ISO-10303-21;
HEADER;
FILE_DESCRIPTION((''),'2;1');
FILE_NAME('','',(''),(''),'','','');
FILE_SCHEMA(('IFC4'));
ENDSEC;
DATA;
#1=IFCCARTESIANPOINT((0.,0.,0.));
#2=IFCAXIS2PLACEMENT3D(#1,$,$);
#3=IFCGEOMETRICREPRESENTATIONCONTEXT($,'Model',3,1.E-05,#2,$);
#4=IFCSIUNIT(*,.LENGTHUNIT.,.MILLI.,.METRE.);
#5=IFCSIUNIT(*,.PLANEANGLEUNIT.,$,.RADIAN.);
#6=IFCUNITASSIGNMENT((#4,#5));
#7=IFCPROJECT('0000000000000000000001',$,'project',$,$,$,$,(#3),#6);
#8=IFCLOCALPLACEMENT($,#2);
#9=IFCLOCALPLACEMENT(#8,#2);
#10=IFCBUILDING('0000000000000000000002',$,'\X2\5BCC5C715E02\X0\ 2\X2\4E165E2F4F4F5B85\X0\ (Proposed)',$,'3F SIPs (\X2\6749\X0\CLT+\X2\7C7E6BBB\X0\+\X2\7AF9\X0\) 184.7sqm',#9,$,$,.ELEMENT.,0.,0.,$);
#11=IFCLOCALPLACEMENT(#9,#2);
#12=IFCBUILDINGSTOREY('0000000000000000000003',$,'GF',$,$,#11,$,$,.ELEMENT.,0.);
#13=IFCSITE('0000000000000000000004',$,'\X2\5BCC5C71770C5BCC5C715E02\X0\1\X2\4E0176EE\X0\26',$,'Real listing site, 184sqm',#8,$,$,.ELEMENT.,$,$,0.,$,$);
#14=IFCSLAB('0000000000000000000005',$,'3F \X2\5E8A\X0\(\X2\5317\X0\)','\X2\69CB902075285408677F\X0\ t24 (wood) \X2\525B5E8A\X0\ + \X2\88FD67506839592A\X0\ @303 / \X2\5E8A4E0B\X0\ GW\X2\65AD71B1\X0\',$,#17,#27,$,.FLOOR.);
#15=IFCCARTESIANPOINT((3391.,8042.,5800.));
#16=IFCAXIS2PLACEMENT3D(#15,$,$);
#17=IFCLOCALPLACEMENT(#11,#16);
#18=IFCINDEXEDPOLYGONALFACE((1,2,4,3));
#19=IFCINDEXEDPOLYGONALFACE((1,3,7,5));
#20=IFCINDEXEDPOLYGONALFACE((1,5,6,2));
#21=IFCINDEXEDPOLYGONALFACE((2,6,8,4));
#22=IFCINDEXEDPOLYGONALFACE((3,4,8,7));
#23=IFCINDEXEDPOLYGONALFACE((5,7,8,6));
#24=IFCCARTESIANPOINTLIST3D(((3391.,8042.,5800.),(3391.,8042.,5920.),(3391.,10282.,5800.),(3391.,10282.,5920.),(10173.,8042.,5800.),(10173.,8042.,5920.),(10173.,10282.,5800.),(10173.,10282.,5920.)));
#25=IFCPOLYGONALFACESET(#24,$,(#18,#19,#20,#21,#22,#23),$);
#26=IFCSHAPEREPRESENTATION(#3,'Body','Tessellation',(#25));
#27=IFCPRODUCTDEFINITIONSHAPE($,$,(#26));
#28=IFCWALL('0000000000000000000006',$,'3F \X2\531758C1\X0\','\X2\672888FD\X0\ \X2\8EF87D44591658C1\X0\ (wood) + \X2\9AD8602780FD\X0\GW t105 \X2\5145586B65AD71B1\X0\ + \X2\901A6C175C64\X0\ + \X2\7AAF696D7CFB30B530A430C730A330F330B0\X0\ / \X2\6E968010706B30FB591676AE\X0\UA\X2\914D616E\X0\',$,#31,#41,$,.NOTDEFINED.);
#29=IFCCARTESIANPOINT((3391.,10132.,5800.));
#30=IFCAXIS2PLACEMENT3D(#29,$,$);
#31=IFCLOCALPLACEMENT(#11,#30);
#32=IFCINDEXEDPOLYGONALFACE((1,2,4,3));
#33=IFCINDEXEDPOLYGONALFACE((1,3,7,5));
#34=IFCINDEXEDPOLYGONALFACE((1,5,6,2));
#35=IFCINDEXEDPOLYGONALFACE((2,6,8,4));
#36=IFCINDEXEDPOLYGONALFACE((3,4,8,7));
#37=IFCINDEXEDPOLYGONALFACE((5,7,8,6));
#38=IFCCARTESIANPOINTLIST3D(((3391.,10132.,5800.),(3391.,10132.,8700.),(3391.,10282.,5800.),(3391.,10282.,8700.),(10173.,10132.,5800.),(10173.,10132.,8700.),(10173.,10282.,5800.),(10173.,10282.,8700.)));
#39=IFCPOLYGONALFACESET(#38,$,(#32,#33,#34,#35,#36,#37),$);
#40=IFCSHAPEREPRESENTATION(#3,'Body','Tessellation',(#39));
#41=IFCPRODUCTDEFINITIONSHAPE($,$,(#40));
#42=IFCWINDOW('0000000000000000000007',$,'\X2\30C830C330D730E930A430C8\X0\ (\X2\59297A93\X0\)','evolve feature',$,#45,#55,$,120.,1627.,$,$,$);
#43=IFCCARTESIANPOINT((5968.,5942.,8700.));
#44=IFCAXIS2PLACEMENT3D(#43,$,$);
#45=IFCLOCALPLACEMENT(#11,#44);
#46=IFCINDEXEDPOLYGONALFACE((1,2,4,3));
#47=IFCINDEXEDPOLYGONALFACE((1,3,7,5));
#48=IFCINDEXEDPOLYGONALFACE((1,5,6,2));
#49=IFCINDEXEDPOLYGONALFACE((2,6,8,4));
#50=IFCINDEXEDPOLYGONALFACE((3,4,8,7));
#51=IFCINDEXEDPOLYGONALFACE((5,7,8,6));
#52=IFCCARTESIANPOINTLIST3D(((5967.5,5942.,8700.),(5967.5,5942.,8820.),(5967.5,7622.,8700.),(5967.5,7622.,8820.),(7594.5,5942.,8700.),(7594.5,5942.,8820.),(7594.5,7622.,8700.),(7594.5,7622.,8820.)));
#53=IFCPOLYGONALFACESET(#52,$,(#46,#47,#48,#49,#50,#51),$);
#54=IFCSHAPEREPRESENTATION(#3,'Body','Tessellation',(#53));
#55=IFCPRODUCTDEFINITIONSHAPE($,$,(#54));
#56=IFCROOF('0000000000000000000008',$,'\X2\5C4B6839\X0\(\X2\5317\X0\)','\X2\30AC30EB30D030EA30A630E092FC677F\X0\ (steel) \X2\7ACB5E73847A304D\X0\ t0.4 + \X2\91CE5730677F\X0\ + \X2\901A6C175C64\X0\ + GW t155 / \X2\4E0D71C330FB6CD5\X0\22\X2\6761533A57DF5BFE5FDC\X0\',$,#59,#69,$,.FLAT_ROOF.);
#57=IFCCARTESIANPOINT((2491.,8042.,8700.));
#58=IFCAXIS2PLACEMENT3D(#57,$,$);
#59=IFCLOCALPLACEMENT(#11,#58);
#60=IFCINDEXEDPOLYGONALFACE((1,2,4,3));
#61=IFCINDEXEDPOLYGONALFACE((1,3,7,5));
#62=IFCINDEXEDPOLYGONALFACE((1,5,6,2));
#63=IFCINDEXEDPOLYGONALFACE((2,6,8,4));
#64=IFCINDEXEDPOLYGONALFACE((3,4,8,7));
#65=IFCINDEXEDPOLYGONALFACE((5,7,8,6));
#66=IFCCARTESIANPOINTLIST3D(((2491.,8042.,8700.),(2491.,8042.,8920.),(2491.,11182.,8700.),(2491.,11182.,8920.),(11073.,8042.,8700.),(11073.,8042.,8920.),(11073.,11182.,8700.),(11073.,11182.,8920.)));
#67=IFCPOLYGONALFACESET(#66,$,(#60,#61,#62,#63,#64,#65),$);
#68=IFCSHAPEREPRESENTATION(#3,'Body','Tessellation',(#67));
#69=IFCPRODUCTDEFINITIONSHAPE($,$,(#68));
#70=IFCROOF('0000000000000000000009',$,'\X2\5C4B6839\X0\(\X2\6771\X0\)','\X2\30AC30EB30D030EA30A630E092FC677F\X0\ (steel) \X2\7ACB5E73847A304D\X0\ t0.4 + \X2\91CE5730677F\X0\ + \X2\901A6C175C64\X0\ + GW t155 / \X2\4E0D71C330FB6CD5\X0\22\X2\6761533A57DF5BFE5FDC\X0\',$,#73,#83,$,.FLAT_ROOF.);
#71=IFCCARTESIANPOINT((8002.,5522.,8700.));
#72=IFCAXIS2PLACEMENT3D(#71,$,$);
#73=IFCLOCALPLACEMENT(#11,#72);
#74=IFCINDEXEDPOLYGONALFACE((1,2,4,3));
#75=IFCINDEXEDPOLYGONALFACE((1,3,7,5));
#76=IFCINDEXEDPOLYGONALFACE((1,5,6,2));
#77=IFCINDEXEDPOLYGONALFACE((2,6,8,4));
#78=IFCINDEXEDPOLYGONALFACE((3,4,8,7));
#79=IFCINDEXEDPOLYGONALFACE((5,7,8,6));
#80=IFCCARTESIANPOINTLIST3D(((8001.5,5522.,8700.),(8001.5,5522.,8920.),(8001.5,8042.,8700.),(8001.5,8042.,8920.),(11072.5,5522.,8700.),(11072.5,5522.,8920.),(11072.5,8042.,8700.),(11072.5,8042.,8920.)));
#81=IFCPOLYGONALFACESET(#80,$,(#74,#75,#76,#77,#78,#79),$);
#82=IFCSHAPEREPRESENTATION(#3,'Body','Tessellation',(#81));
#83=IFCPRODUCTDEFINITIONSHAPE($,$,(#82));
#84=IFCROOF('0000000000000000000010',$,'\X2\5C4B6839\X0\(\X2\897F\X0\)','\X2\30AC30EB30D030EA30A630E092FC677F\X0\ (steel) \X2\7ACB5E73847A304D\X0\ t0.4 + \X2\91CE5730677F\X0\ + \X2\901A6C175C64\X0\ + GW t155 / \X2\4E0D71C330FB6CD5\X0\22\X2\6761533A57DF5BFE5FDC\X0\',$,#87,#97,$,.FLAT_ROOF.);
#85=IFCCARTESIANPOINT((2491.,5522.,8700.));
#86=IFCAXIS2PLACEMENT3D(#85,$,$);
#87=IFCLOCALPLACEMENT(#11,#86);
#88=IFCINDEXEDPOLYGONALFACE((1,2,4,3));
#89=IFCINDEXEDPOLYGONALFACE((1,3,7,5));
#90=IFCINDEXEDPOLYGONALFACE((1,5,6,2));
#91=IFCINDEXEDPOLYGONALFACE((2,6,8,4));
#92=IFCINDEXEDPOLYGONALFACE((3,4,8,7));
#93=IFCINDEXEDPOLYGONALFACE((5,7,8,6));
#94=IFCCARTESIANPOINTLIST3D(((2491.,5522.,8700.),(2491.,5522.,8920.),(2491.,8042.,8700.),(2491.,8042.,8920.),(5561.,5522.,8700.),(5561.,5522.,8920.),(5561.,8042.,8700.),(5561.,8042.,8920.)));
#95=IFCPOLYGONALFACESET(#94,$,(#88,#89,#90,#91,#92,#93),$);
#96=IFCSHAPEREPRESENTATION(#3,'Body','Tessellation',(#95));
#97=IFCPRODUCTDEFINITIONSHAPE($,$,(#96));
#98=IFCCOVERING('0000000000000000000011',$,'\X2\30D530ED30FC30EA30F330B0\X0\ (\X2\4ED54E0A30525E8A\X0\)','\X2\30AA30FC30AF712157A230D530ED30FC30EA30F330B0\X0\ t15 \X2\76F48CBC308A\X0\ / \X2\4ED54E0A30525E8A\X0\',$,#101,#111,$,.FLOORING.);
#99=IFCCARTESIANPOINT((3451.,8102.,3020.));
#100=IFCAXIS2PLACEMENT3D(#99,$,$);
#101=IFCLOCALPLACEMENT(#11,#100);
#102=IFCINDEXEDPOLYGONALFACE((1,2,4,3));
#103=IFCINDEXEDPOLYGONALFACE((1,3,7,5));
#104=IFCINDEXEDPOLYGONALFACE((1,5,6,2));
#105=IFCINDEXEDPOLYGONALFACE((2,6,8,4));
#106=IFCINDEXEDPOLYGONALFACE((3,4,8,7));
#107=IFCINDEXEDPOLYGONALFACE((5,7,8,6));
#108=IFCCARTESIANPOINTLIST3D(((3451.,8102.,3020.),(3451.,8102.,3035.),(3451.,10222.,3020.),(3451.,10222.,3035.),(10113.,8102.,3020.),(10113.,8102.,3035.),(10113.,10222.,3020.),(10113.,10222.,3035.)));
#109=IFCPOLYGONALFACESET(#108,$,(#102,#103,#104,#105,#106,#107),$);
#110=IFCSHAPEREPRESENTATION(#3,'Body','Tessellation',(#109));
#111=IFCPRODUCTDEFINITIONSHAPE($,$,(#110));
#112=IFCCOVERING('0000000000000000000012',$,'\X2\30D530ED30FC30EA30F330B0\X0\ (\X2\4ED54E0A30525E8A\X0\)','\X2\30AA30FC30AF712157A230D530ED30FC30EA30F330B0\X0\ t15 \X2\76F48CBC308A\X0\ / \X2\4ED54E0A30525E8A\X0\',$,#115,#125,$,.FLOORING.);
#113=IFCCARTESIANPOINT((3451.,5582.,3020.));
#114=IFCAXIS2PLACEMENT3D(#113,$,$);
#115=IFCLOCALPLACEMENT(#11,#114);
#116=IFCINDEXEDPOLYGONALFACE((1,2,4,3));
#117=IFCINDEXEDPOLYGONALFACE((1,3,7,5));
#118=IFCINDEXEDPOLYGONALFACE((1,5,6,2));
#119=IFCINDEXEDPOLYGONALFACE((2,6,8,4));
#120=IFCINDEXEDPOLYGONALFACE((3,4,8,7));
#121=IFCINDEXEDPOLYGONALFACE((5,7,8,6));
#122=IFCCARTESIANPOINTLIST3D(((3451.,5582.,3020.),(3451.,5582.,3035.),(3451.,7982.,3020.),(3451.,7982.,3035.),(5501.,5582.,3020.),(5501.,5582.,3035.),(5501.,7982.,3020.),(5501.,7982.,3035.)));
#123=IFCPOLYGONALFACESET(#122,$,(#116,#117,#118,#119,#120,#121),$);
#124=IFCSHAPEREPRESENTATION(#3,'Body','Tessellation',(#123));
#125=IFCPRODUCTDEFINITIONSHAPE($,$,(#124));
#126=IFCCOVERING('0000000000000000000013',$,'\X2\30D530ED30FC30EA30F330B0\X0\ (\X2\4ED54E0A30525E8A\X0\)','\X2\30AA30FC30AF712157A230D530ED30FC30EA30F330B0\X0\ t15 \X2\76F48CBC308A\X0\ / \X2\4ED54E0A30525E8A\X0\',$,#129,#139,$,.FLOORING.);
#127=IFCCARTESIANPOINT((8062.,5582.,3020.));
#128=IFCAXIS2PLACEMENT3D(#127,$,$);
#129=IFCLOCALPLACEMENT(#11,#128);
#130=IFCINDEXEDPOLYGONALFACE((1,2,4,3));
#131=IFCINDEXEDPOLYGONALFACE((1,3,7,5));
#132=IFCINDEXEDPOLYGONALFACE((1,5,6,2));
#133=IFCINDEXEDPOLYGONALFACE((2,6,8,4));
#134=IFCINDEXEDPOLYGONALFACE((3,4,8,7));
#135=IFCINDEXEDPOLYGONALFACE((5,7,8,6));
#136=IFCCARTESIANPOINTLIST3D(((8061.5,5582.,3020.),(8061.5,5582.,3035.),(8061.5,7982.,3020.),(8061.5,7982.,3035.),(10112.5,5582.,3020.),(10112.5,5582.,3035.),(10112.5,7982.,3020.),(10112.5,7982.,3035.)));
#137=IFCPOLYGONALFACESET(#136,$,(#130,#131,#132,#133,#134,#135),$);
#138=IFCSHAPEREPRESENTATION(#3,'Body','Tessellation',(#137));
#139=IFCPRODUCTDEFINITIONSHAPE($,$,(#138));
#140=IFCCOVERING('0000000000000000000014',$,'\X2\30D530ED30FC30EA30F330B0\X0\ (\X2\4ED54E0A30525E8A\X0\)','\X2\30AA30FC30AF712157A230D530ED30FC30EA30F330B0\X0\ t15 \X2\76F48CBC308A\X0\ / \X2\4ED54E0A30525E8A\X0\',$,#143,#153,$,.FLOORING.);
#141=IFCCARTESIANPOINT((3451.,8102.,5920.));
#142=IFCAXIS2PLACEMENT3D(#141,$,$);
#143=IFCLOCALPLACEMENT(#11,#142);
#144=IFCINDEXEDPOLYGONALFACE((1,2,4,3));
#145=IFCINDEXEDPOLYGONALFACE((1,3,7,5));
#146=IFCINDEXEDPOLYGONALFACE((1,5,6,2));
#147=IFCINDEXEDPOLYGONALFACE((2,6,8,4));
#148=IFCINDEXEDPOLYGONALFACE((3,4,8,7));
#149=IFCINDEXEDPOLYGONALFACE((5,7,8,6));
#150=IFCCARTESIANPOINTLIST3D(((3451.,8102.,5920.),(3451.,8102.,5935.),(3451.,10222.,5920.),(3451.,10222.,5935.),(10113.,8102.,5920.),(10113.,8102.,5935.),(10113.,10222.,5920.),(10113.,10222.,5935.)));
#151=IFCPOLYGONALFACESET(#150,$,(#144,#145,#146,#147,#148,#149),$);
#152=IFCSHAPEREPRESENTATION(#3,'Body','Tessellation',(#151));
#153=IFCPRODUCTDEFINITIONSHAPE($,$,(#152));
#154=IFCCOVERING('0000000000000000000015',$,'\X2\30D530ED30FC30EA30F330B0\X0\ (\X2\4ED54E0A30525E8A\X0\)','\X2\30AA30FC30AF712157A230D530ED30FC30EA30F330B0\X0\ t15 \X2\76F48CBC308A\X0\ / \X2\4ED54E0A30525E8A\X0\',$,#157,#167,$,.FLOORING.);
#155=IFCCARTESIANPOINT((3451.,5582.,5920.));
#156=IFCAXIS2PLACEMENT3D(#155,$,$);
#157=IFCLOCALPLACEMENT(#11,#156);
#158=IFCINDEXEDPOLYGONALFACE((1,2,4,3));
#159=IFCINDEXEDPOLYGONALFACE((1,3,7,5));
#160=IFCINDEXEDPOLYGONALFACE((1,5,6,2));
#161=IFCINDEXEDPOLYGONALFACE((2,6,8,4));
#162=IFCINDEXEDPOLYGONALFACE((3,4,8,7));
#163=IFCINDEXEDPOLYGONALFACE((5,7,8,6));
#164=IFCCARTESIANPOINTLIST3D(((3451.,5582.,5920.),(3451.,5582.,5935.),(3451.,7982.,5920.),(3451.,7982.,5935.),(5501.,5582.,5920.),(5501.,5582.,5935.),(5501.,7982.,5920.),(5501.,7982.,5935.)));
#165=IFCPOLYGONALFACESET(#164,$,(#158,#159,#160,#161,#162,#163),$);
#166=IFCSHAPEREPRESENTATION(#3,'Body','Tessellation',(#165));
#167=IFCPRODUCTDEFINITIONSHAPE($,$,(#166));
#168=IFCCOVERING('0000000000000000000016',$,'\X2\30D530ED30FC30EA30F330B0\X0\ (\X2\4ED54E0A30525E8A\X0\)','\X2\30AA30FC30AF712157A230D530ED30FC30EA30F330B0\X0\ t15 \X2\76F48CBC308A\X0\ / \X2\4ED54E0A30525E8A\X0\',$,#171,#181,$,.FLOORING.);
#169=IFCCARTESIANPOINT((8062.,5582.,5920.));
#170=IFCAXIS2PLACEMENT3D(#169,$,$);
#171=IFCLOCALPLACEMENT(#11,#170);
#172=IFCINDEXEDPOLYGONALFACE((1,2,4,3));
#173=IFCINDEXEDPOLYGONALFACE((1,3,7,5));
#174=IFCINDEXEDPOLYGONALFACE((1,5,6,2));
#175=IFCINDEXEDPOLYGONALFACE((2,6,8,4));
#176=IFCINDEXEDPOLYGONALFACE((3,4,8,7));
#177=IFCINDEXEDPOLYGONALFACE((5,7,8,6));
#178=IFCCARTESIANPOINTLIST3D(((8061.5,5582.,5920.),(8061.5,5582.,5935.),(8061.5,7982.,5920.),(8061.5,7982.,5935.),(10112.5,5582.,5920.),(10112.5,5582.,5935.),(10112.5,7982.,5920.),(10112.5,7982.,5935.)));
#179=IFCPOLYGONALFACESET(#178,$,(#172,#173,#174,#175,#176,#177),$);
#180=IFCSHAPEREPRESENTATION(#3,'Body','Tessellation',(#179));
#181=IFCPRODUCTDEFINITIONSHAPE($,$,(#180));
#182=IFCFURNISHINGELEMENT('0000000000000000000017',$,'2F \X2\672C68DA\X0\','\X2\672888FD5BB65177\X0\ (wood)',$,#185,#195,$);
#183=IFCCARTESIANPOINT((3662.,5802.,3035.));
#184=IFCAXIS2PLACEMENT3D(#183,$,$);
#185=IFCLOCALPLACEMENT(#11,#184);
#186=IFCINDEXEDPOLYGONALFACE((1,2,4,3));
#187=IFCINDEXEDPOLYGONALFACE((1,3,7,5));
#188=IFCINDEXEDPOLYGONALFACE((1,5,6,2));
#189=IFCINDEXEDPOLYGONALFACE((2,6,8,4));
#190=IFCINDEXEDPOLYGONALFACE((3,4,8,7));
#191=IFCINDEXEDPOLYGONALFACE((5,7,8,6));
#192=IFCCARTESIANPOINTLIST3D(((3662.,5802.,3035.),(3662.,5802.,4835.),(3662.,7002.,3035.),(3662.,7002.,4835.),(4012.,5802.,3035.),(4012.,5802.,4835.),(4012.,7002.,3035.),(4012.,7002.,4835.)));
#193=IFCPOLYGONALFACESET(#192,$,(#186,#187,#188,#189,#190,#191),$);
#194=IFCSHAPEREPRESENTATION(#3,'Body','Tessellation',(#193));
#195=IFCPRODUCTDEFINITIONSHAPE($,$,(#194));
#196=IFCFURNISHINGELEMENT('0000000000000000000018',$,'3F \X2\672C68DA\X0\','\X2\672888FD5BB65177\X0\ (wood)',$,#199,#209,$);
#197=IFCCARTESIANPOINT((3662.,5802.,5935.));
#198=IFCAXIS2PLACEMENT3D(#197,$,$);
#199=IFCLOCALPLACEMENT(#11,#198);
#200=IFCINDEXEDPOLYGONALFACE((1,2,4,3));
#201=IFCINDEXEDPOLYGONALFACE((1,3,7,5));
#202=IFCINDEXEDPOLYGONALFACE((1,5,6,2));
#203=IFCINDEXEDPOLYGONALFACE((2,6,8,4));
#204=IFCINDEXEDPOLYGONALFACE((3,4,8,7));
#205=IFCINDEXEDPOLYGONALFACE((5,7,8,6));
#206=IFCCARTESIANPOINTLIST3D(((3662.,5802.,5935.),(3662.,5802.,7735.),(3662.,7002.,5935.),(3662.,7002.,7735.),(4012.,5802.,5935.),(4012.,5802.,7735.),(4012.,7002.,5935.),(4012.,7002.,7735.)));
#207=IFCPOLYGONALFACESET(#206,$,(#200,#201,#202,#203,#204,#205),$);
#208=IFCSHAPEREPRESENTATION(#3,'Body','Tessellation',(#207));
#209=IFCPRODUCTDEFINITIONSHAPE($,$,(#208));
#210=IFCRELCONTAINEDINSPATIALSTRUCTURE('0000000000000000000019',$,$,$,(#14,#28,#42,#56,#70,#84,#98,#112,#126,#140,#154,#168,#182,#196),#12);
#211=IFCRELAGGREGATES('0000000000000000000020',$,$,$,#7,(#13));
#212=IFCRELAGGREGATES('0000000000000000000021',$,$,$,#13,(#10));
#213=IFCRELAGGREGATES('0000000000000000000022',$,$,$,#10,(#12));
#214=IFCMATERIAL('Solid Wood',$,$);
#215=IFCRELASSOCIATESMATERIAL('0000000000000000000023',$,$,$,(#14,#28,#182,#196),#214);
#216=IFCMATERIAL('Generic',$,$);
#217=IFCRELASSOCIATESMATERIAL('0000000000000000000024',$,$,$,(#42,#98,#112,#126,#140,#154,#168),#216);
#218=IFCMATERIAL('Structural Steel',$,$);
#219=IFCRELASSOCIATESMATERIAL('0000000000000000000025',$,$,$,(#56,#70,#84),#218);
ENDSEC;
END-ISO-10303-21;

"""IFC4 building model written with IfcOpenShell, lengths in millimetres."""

from ifc_helpers import new_model, si_unit, frame, frame_2d, origin, place, context, project, spatial, rectangle, extrude, material, element, save


model = new_model("IFC4")

# Units and contexts
model_context = context("Model", 3, precision=1e-05, world=origin())
ifc_project = project(units=[si_unit("LENGTHUNIT", "METRE", prefix="MILLI"), si_unit("PLANEANGLEUNIT", "RADIAN")], contexts=[model_context])

# Site, building, storey
site_placement = place(None, origin())
site = spatial("IfcSite", under=ifc_project, at=site_placement, Name="富山県富山市1丁目26", ObjectType="Real listing site, 184sqm", CompositionType="ELEMENT", RefElevation=0.0)
building_placement = place(site_placement, origin())
building = spatial("IfcBuilding", under=site, at=building_placement, Name="富山市 2世帯住宅 (Proposed)", ObjectType="3F SIPs (杉CLT+籾殻+竹) 184.7sqm", CompositionType="ELEMENT", ElevationOfRefHeight=0.0, ElevationOfTerrain=0.0)
storey_placement = place(building_placement, origin())
storey = spatial("IfcBuildingStorey", under=building, at=storey_placement, Name="GF", CompositionType="ELEMENT", Elevation=0.0)

# Slab
ifc_material_1 = material(Name="Solid Wood")
slab_placement = place(storey_placement, frame((3391.0, 8042.0, 5800.0)))
element("IfcSlab", 1, at=slab_placement, inside=storey, material=ifc_material_1, Name="3F 床(北)", Description="構造用合板 t24 (wood) 剛床 + 製材根太 @303 / 床下 GW断熱", PredefinedType="FLOOR", context=model_context, shape_type="SweptSolid", body=[
    extrude(rectangle(XDim=6782.0, YDim=2240.0, at=frame_2d((3391.0, 1120.0))), frame((3391.0, 8042.0, 5800.0)), (0.0, 0.0, 1.0), 120.0),
])

# Wall
wall_1_placement = place(storey_placement, frame((3391.0, 10132.0, 5800.0)))
element("IfcWall", 2, at=wall_1_placement, inside=storey, material=ifc_material_1, Name="3F 北壁", Description="木製 軸組外壁 (wood) + 高性能GW t105 充填断熱 + 通気層 + 窯業系サイディング / 準耐火・外皮UA配慮", PredefinedType="NOTDEFINED", context=model_context, shape_type="SweptSolid", body=[
    extrude(rectangle(XDim=6782.0, YDim=150.0, at=frame_2d((3391.0, 75.0))), frame((3391.0, 10132.0, 5800.0)), (0.0, 0.0, 1.0), 2900.0),
])

# Window
ifc_material_2 = material(Name="Generic")
window_1_placement = place(storey_placement, frame((5968.0, 5942.0, 8700.0)))
element("IfcWindow", 3, at=window_1_placement, inside=storey, material=ifc_material_2, Name="トップライト (天窓)", Description="evolve feature", OverallHeight=120.0, OverallWidth=1627.0, context=model_context, shape_type="SweptSolid", body=[
    extrude(rectangle(XDim=1627.0, YDim=1680.0, at=frame_2d((813.0, 840.0))), frame((5968.0, 5942.0, 8700.0)), (0.0, 0.0, 1.0), 120.0),
])

# Roofs
ifc_material_3 = material(Name="Structural Steel")
roof_1_placement = place(storey_placement, frame((2491.0, 8042.0, 8700.0)))
element("IfcRoof", 4, at=roof_1_placement, inside=storey, material=ifc_material_3, Name="屋根(北)", Description="ガルバリウム鋼板 (steel) 立平葺き t0.4 + 野地板 + 通気層 + GW t155 / 不燃・法22条区域対応", PredefinedType="FLAT_ROOF", context=model_context, shape_type="SweptSolid", body=[
    extrude(rectangle(XDim=8582.0, YDim=3140.0, at=frame_2d((4291.0, 1570.0))), frame((2491.0, 8042.0, 8700.0)), (0.0, 0.0, 1.0), 220.0),
])
roof_2_placement = place(storey_placement, frame((8002.0, 5522.0, 8700.0)))
element("IfcRoof", 5, at=roof_2_placement, inside=storey, material=ifc_material_3, Name="屋根(東)", Description="ガルバリウム鋼板 (steel) 立平葺き t0.4 + 野地板 + 通気層 + GW t155 / 不燃・法22条区域対応", PredefinedType="FLAT_ROOF", context=model_context, shape_type="SweptSolid", body=[
    extrude(rectangle(XDim=3071.0, YDim=2520.0, at=frame_2d((1535.0, 1260.0))), frame((8002.0, 5522.0, 8700.0)), (0.0, 0.0, 1.0), 220.0),
])
roof_3_placement = place(storey_placement, frame((2491.0, 5522.0, 8700.0)))
element("IfcRoof", 6, at=roof_3_placement, inside=storey, material=ifc_material_3, Name="屋根(西)", Description="ガルバリウム鋼板 (steel) 立平葺き t0.4 + 野地板 + 通気層 + GW t155 / 不燃・法22条区域対応", PredefinedType="FLAT_ROOF", context=model_context, shape_type="SweptSolid", body=[
    extrude(rectangle(XDim=3070.0, YDim=2520.0, at=frame_2d((1535.0, 1260.0))), frame((2491.0, 5522.0, 8700.0)), (0.0, 0.0, 1.0), 220.0),
])

# Coverings
covering_1_placement = place(storey_placement, frame((3451.0, 8102.0, 3020.0)))
element("IfcCovering", 7, at=covering_1_placement, inside=storey, material=ifc_material_2, Name="フローリング (仕上げ床)", Description="オーク無垢フローリング t15 直貼り / 仕上げ床", PredefinedType="FLOORING", context=model_context, shape_type="SweptSolid", body=[
    extrude(rectangle(XDim=6662.0, YDim=2120.0, at=frame_2d((3331.0, 1060.0))), frame((3451.0, 8102.0, 3020.0)), (0.0, 0.0, 1.0), 15.0),
])
covering_2_placement = place(storey_placement, frame((3451.0, 5582.0, 3020.0)))
element("IfcCovering", 8, at=covering_2_placement, inside=storey, material=ifc_material_2, Name="フローリング (仕上げ床)", Description="オーク無垢フローリング t15 直貼り / 仕上げ床", PredefinedType="FLOORING", context=model_context, shape_type="SweptSolid", body=[
    extrude(rectangle(XDim=2050.0, YDim=2400.0, at=frame_2d((1025.0, 1200.0))), frame((3451.0, 5582.0, 3020.0)), (0.0, 0.0, 1.0), 15.0),
])
covering_3_placement = place(storey_placement, frame((8062.0, 5582.0, 3020.0)))
element("IfcCovering", 9, at=covering_3_placement, inside=storey, material=ifc_material_2, Name="フローリング (仕上げ床)", Description="オーク無垢フローリング t15 直貼り / 仕上げ床", PredefinedType="FLOORING", context=model_context, shape_type="SweptSolid", body=[
    extrude(rectangle(XDim=2051.0, YDim=2400.0, at=frame_2d((1025.0, 1200.0))), frame((8062.0, 5582.0, 3020.0)), (0.0, 0.0, 1.0), 15.0),
])
covering_4_placement = place(storey_placement, frame((3451.0, 8102.0, 5920.0)))
element("IfcCovering", 10, at=covering_4_placement, inside=storey, material=ifc_material_2, Name="フローリング (仕上げ床)", Description="オーク無垢フローリング t15 直貼り / 仕上げ床", PredefinedType="FLOORING", context=model_context, shape_type="SweptSolid", body=[
    extrude(rectangle(XDim=6662.0, YDim=2120.0, at=frame_2d((3331.0, 1060.0))), frame((3451.0, 8102.0, 5920.0)), (0.0, 0.0, 1.0), 15.0),
])
covering_5_placement = place(storey_placement, frame((3451.0, 5582.0, 5920.0)))
element("IfcCovering", 11, at=covering_5_placement, inside=storey, material=ifc_material_2, Name="フローリング (仕上げ床)", Description="オーク無垢フローリング t15 直貼り / 仕上げ床", PredefinedType="FLOORING", context=model_context, shape_type="SweptSolid", body=[
    extrude(rectangle(XDim=2050.0, YDim=2400.0, at=frame_2d((1025.0, 1200.0))), frame((3451.0, 5582.0, 5920.0)), (0.0, 0.0, 1.0), 15.0),
])
covering_6_placement = place(storey_placement, frame((8062.0, 5582.0, 5920.0)))
element("IfcCovering", 12, at=covering_6_placement, inside=storey, material=ifc_material_2, Name="フローリング (仕上げ床)", Description="オーク無垢フローリング t15 直貼り / 仕上げ床", PredefinedType="FLOORING", context=model_context, shape_type="SweptSolid", body=[
    extrude(rectangle(XDim=2051.0, YDim=2400.0, at=frame_2d((1025.0, 1200.0))), frame((8062.0, 5582.0, 5920.0)), (0.0, 0.0, 1.0), 15.0),
])

# Furnishing elements
furnishing_1_placement = place(storey_placement, frame((3662.0, 5802.0, 3035.0)))
element("IfcFurnishingElement", 13, at=furnishing_1_placement, inside=storey, material=ifc_material_1, Name="2F 本棚", Description="木製家具 (wood)", context=model_context, shape_type="SweptSolid", body=[
    extrude(rectangle(XDim=350.0, YDim=1200.0, at=frame_2d((175.0, 600.0))), frame((3662.0, 5802.0, 3035.0)), (0.0, 0.0, 1.0), 1800.0),
])
furnishing_2_placement = place(storey_placement, frame((3662.0, 5802.0, 5935.0)))
element("IfcFurnishingElement", 14, at=furnishing_2_placement, inside=storey, material=ifc_material_1, Name="3F 本棚", Description="木製家具 (wood)", context=model_context, shape_type="SweptSolid", body=[
    extrude(rectangle(XDim=350.0, YDim=1200.0, at=frame_2d((175.0, 600.0))), frame((3662.0, 5802.0, 5935.0)), (0.0, 0.0, 1.0), 1800.0),
])

save(model, "model.ifc")
